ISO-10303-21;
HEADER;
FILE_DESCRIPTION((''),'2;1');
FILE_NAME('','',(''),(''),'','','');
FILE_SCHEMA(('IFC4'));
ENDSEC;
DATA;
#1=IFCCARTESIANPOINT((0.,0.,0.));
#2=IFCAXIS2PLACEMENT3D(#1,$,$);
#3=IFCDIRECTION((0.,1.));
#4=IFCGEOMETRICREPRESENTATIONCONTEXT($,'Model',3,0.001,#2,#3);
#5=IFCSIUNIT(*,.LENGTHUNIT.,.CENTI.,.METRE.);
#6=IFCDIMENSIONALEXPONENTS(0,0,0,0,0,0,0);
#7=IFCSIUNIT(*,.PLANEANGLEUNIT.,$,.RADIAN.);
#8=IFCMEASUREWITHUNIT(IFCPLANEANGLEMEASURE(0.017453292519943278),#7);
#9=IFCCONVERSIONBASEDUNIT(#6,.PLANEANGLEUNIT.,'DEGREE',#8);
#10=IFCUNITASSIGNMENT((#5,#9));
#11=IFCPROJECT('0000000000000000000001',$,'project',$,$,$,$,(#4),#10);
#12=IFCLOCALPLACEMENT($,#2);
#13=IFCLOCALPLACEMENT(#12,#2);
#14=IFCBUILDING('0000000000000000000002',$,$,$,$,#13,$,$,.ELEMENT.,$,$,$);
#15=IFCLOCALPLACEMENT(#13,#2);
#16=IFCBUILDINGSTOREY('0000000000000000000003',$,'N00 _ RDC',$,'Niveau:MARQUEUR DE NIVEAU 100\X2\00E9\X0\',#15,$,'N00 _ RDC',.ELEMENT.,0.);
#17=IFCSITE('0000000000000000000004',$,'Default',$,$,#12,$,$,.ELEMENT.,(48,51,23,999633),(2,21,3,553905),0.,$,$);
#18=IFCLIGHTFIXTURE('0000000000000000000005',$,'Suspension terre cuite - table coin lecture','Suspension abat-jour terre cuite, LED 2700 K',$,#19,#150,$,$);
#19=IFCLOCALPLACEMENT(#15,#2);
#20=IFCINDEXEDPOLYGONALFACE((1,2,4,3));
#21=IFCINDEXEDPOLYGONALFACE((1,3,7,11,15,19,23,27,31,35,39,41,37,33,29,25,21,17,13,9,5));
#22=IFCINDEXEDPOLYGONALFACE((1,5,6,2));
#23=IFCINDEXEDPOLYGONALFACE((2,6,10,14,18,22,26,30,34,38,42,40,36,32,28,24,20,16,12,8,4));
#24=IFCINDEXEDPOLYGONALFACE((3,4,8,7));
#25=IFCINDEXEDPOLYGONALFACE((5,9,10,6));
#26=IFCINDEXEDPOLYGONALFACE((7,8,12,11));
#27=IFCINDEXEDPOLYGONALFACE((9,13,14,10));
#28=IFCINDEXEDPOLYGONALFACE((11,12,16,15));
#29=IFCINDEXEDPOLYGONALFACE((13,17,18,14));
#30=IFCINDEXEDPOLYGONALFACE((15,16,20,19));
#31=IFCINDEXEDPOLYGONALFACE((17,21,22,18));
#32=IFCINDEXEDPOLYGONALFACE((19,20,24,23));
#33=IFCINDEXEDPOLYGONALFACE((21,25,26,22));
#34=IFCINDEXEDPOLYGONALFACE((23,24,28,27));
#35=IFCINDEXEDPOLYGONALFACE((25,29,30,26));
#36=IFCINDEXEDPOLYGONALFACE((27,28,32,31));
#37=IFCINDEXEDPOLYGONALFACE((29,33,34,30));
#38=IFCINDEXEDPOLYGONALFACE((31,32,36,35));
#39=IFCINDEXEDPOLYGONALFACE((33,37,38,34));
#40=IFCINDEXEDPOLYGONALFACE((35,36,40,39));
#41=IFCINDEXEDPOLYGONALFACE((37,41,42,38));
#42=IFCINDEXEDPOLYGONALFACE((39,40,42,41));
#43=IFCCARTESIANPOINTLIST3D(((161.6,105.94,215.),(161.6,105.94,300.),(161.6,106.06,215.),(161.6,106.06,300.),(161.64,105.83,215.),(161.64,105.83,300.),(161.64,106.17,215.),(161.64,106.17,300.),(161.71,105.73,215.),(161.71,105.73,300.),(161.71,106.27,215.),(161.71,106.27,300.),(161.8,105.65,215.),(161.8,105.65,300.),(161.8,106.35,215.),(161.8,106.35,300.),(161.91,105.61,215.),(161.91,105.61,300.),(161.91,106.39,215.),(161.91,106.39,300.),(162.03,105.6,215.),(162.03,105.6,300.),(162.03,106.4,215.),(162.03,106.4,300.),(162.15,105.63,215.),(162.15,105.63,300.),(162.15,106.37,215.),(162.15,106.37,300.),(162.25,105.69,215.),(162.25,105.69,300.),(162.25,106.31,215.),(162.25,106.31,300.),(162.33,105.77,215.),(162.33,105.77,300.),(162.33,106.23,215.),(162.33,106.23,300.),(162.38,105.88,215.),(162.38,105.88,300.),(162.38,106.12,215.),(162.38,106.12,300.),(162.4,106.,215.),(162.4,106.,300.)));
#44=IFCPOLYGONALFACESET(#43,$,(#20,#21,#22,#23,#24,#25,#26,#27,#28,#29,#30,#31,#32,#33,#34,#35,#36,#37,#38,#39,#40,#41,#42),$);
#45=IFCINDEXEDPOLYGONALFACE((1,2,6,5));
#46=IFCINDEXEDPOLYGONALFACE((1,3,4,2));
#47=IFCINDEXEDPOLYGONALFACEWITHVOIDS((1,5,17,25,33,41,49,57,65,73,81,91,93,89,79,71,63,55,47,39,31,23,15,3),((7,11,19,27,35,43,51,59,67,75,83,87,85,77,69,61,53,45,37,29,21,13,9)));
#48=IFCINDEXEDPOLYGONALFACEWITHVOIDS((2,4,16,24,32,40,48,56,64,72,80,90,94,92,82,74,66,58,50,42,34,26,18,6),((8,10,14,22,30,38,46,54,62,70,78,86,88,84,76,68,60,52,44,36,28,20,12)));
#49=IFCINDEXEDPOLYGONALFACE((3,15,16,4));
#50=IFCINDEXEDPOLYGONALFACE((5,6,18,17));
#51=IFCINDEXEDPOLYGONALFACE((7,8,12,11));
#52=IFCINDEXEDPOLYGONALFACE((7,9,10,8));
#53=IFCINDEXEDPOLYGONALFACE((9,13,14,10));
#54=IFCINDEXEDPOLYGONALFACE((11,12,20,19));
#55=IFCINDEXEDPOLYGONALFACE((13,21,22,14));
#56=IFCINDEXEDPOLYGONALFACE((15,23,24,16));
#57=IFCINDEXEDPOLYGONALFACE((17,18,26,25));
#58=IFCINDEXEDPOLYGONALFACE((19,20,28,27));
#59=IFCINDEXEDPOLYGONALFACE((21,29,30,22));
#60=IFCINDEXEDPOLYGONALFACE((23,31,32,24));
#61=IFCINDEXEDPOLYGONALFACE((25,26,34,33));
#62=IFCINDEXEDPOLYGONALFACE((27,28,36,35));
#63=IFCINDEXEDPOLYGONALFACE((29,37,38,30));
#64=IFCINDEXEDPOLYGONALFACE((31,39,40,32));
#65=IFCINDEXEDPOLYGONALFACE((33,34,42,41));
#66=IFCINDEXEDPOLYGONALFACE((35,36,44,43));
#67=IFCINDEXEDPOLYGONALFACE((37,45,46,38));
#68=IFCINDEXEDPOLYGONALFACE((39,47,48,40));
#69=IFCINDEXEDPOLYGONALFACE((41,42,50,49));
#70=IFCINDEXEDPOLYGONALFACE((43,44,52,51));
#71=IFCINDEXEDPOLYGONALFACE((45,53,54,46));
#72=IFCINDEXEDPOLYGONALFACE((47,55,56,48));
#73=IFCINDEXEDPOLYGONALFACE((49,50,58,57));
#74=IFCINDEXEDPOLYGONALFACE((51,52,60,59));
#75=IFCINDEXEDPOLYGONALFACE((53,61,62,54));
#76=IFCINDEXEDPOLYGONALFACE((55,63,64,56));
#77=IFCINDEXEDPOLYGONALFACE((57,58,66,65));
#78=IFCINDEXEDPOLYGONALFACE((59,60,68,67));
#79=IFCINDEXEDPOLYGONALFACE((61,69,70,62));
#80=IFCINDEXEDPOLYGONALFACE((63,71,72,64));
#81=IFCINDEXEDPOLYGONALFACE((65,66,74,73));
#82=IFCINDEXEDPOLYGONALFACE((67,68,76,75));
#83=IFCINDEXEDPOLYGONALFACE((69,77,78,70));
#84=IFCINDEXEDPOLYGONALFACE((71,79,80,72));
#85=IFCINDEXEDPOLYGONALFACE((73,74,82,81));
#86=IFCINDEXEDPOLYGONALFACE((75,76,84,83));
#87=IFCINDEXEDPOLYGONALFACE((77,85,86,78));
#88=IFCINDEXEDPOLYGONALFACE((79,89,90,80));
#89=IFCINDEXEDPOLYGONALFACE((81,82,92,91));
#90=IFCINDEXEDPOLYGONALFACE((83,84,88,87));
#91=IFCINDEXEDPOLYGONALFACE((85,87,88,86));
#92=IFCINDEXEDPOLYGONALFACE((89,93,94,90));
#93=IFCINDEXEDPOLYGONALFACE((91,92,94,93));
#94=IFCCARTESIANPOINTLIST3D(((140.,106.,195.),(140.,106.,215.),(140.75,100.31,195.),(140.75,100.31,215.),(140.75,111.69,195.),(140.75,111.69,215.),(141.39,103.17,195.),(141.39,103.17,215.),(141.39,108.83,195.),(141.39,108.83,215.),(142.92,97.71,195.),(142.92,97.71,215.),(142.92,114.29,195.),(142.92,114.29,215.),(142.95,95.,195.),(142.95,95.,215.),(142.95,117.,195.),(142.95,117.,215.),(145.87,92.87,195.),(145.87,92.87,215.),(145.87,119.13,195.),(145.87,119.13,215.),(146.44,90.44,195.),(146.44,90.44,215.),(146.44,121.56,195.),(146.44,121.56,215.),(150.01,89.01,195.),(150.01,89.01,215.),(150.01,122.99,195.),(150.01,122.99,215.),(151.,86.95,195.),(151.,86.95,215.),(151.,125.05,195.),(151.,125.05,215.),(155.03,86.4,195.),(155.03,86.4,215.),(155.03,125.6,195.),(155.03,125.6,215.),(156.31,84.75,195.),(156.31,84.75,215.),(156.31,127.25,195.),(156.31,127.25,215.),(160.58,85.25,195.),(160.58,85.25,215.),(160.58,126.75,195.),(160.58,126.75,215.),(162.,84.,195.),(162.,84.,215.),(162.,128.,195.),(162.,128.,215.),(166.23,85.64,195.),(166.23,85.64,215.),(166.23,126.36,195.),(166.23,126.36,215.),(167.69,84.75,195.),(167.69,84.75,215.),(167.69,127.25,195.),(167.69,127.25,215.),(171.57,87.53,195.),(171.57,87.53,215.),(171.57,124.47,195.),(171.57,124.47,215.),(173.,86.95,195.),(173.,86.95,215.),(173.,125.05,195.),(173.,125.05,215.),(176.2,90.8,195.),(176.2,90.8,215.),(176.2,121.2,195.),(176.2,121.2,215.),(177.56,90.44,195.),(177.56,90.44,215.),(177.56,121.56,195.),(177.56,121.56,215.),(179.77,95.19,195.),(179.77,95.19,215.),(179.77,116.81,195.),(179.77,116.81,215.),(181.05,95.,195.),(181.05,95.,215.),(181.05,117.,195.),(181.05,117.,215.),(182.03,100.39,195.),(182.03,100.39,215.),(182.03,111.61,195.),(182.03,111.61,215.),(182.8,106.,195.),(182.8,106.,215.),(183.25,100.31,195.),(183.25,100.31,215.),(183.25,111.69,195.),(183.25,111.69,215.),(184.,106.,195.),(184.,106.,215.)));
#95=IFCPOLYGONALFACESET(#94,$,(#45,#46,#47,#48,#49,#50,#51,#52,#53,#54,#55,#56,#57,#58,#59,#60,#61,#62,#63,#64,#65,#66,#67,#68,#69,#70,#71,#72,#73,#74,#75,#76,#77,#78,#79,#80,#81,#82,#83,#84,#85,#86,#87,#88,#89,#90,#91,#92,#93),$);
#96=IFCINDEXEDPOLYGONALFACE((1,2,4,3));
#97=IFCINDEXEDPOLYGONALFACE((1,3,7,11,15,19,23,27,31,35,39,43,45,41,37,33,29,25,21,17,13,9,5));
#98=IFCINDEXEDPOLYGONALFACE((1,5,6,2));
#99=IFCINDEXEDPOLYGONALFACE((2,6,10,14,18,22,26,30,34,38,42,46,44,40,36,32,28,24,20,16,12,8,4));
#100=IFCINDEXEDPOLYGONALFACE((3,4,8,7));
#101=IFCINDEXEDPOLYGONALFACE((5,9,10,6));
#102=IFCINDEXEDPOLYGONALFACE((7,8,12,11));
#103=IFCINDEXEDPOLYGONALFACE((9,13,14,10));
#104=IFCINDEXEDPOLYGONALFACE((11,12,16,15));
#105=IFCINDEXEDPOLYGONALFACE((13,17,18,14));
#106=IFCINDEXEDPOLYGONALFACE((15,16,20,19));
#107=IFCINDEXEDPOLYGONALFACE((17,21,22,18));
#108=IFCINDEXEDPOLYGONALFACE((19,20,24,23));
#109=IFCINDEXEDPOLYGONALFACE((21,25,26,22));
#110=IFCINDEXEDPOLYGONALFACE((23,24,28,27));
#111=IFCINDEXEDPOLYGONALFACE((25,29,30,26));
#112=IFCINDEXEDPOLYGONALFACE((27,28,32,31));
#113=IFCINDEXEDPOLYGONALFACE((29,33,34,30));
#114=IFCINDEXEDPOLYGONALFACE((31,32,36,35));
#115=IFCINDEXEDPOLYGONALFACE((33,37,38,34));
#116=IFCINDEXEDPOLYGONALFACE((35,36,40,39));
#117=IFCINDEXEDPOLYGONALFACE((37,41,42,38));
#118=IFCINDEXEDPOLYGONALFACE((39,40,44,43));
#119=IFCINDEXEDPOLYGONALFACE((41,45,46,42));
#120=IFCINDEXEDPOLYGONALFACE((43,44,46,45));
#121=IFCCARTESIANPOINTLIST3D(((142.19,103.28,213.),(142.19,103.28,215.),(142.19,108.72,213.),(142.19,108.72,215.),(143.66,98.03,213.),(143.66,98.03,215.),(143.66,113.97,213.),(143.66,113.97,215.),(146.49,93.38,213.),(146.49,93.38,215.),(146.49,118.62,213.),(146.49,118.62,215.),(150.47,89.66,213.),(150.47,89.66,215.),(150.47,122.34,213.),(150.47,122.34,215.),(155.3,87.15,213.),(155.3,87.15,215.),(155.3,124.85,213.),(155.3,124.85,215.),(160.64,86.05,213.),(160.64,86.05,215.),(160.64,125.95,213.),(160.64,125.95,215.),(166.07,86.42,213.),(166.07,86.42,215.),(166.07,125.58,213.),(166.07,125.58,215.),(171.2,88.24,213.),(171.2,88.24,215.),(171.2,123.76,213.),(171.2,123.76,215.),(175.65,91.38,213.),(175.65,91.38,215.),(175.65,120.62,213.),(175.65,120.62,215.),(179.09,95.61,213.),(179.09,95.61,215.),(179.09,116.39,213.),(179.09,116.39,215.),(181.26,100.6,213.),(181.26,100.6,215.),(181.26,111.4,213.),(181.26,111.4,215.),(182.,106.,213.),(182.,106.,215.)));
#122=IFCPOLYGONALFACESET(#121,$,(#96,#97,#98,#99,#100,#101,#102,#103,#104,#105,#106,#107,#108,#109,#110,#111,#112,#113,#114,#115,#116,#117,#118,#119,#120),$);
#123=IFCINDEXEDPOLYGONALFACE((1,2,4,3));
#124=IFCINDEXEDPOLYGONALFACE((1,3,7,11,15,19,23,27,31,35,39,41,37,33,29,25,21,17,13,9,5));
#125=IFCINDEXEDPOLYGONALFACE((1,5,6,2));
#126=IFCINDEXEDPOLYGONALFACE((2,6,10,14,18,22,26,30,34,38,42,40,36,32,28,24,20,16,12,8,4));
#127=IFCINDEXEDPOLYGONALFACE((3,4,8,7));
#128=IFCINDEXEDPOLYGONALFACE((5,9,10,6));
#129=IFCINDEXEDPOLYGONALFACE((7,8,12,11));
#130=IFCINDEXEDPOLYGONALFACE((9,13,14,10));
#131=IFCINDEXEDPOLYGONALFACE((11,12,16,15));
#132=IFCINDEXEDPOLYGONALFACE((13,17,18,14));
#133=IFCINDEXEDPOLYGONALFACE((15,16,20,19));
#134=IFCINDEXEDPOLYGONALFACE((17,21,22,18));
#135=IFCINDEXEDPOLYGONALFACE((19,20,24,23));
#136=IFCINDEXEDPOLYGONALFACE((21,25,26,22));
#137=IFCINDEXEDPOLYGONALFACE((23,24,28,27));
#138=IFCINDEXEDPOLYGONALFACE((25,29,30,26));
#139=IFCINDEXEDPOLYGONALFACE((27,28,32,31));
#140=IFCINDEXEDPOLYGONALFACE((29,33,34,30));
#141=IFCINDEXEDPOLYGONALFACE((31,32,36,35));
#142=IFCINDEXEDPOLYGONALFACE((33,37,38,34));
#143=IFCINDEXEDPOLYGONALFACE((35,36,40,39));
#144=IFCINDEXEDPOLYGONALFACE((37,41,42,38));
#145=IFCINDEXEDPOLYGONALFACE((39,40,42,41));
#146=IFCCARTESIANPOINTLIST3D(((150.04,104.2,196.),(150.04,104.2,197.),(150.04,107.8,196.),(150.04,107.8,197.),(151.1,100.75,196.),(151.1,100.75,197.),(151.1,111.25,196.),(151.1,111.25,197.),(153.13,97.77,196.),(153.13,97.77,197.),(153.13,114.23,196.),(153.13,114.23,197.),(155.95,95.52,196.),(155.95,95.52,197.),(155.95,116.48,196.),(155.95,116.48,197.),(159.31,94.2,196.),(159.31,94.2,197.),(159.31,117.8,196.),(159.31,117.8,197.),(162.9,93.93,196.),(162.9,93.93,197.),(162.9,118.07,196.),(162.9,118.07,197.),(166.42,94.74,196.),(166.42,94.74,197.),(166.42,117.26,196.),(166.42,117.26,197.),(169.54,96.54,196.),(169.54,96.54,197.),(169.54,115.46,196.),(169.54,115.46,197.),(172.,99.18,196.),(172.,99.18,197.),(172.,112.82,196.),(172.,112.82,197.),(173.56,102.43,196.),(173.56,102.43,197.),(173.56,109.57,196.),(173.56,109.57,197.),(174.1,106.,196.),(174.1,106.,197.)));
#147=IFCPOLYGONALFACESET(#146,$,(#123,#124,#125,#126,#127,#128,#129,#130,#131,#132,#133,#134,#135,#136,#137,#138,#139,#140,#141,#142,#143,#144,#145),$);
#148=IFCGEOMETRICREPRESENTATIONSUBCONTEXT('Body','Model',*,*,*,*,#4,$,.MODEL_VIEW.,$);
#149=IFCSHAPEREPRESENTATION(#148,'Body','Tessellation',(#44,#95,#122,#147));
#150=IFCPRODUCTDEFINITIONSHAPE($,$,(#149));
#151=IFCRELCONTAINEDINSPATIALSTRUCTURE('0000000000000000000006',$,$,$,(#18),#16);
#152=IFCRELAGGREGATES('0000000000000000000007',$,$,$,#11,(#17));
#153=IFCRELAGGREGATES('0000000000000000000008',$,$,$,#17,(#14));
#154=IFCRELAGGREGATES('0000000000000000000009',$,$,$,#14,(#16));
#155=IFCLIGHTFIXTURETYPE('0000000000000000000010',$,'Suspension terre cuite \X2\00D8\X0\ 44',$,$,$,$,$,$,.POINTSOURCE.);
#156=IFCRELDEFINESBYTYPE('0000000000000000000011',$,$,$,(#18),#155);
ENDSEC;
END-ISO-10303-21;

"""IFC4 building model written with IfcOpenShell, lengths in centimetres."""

from ifc_helpers import new_model, entity, si_unit, converted_unit, direction, frame, frame_2d, origin, origin_with_axes, place, context, subcontext, project, spatial, circle, hollow_circle, extrude, type_object, element, save


model = new_model("IFC4")

# Units and contexts
model_context = context("Model", 3, precision=0.001, world=origin(), true_north=direction((0.0, 1.0)))
body_context = subcontext(model_context, "Body", "Model", "MODEL_VIEW")
ifc_project = project(units=[si_unit("LENGTHUNIT", "METRE", prefix="CENTI"), converted_unit("PLANEANGLEUNIT", "DEGREE", entity("IfcPlaneAngleMeasure", 0.017453292519943278), si_unit("PLANEANGLEUNIT", "RADIAN"), dimensions=[0, 0, 0, 0, 0, 0, 0])], contexts=[model_context])

# Site, building, storey
site_placement = place(None, origin())
site = spatial("IfcSite", under=ifc_project, at=site_placement, Name="Default", CompositionType="ELEMENT", RefLatitude=(48, 51, 23, 999633), RefLongitude=(2, 21, 3, 553905), RefElevation=0.0)
building_placement = place(site_placement, origin())
building = spatial("IfcBuilding", under=site, at=building_placement, CompositionType="ELEMENT")
storey_placement = place(building_placement, origin())
storey = spatial("IfcBuildingStorey", under=building, at=storey_placement, Name="N00 _ RDC", ObjectType="Niveau:MARQUEUR DE NIVEAU 100é", LongName="N00 _ RDC", CompositionType="ELEMENT", Elevation=0.0)

# Light fixture
light_fixture_type_1 = type_object("IfcLightFixtureType", Name="Suspension terre cuite Ø 44", PredefinedType="POINTSOURCE")
light_fixture_1_placement = place(storey_placement, origin_with_axes())
element("IfcLightFixture", 1, at=light_fixture_1_placement, inside=storey, type_object=light_fixture_type_1, Name="Suspension terre cuite - table coin lecture", Description="Suspension abat-jour terre cuite, LED 2700 K", context=body_context, shape_type="SweptSolid", body=[
    extrude(circle(Radius=0.4, at=frame_2d((162.0, 106.0))), frame((0.0, 0.0, 215.0)), (0.0, 0.0, 1.0), 85.0),
    extrude(hollow_circle(Radius=22.0, WallThickness=1.2, at=frame_2d((162.0, 106.0))), frame((0.0, 0.0, 195.0)), (0.0, 0.0, 1.0), 20.0),
    extrude(circle(Radius=20.0, at=frame_2d((162.0, 106.0))), frame((0.0, 0.0, 213.0)), (0.0, 0.0, 1.0), 2.0),
    extrude(circle(Radius=12.1, at=frame_2d((162.0, 106.0))), frame((0.0, 0.0, 196.0)), (0.0, 0.0, 1.0), 1.0),
])

save(model, "model.ifc")
